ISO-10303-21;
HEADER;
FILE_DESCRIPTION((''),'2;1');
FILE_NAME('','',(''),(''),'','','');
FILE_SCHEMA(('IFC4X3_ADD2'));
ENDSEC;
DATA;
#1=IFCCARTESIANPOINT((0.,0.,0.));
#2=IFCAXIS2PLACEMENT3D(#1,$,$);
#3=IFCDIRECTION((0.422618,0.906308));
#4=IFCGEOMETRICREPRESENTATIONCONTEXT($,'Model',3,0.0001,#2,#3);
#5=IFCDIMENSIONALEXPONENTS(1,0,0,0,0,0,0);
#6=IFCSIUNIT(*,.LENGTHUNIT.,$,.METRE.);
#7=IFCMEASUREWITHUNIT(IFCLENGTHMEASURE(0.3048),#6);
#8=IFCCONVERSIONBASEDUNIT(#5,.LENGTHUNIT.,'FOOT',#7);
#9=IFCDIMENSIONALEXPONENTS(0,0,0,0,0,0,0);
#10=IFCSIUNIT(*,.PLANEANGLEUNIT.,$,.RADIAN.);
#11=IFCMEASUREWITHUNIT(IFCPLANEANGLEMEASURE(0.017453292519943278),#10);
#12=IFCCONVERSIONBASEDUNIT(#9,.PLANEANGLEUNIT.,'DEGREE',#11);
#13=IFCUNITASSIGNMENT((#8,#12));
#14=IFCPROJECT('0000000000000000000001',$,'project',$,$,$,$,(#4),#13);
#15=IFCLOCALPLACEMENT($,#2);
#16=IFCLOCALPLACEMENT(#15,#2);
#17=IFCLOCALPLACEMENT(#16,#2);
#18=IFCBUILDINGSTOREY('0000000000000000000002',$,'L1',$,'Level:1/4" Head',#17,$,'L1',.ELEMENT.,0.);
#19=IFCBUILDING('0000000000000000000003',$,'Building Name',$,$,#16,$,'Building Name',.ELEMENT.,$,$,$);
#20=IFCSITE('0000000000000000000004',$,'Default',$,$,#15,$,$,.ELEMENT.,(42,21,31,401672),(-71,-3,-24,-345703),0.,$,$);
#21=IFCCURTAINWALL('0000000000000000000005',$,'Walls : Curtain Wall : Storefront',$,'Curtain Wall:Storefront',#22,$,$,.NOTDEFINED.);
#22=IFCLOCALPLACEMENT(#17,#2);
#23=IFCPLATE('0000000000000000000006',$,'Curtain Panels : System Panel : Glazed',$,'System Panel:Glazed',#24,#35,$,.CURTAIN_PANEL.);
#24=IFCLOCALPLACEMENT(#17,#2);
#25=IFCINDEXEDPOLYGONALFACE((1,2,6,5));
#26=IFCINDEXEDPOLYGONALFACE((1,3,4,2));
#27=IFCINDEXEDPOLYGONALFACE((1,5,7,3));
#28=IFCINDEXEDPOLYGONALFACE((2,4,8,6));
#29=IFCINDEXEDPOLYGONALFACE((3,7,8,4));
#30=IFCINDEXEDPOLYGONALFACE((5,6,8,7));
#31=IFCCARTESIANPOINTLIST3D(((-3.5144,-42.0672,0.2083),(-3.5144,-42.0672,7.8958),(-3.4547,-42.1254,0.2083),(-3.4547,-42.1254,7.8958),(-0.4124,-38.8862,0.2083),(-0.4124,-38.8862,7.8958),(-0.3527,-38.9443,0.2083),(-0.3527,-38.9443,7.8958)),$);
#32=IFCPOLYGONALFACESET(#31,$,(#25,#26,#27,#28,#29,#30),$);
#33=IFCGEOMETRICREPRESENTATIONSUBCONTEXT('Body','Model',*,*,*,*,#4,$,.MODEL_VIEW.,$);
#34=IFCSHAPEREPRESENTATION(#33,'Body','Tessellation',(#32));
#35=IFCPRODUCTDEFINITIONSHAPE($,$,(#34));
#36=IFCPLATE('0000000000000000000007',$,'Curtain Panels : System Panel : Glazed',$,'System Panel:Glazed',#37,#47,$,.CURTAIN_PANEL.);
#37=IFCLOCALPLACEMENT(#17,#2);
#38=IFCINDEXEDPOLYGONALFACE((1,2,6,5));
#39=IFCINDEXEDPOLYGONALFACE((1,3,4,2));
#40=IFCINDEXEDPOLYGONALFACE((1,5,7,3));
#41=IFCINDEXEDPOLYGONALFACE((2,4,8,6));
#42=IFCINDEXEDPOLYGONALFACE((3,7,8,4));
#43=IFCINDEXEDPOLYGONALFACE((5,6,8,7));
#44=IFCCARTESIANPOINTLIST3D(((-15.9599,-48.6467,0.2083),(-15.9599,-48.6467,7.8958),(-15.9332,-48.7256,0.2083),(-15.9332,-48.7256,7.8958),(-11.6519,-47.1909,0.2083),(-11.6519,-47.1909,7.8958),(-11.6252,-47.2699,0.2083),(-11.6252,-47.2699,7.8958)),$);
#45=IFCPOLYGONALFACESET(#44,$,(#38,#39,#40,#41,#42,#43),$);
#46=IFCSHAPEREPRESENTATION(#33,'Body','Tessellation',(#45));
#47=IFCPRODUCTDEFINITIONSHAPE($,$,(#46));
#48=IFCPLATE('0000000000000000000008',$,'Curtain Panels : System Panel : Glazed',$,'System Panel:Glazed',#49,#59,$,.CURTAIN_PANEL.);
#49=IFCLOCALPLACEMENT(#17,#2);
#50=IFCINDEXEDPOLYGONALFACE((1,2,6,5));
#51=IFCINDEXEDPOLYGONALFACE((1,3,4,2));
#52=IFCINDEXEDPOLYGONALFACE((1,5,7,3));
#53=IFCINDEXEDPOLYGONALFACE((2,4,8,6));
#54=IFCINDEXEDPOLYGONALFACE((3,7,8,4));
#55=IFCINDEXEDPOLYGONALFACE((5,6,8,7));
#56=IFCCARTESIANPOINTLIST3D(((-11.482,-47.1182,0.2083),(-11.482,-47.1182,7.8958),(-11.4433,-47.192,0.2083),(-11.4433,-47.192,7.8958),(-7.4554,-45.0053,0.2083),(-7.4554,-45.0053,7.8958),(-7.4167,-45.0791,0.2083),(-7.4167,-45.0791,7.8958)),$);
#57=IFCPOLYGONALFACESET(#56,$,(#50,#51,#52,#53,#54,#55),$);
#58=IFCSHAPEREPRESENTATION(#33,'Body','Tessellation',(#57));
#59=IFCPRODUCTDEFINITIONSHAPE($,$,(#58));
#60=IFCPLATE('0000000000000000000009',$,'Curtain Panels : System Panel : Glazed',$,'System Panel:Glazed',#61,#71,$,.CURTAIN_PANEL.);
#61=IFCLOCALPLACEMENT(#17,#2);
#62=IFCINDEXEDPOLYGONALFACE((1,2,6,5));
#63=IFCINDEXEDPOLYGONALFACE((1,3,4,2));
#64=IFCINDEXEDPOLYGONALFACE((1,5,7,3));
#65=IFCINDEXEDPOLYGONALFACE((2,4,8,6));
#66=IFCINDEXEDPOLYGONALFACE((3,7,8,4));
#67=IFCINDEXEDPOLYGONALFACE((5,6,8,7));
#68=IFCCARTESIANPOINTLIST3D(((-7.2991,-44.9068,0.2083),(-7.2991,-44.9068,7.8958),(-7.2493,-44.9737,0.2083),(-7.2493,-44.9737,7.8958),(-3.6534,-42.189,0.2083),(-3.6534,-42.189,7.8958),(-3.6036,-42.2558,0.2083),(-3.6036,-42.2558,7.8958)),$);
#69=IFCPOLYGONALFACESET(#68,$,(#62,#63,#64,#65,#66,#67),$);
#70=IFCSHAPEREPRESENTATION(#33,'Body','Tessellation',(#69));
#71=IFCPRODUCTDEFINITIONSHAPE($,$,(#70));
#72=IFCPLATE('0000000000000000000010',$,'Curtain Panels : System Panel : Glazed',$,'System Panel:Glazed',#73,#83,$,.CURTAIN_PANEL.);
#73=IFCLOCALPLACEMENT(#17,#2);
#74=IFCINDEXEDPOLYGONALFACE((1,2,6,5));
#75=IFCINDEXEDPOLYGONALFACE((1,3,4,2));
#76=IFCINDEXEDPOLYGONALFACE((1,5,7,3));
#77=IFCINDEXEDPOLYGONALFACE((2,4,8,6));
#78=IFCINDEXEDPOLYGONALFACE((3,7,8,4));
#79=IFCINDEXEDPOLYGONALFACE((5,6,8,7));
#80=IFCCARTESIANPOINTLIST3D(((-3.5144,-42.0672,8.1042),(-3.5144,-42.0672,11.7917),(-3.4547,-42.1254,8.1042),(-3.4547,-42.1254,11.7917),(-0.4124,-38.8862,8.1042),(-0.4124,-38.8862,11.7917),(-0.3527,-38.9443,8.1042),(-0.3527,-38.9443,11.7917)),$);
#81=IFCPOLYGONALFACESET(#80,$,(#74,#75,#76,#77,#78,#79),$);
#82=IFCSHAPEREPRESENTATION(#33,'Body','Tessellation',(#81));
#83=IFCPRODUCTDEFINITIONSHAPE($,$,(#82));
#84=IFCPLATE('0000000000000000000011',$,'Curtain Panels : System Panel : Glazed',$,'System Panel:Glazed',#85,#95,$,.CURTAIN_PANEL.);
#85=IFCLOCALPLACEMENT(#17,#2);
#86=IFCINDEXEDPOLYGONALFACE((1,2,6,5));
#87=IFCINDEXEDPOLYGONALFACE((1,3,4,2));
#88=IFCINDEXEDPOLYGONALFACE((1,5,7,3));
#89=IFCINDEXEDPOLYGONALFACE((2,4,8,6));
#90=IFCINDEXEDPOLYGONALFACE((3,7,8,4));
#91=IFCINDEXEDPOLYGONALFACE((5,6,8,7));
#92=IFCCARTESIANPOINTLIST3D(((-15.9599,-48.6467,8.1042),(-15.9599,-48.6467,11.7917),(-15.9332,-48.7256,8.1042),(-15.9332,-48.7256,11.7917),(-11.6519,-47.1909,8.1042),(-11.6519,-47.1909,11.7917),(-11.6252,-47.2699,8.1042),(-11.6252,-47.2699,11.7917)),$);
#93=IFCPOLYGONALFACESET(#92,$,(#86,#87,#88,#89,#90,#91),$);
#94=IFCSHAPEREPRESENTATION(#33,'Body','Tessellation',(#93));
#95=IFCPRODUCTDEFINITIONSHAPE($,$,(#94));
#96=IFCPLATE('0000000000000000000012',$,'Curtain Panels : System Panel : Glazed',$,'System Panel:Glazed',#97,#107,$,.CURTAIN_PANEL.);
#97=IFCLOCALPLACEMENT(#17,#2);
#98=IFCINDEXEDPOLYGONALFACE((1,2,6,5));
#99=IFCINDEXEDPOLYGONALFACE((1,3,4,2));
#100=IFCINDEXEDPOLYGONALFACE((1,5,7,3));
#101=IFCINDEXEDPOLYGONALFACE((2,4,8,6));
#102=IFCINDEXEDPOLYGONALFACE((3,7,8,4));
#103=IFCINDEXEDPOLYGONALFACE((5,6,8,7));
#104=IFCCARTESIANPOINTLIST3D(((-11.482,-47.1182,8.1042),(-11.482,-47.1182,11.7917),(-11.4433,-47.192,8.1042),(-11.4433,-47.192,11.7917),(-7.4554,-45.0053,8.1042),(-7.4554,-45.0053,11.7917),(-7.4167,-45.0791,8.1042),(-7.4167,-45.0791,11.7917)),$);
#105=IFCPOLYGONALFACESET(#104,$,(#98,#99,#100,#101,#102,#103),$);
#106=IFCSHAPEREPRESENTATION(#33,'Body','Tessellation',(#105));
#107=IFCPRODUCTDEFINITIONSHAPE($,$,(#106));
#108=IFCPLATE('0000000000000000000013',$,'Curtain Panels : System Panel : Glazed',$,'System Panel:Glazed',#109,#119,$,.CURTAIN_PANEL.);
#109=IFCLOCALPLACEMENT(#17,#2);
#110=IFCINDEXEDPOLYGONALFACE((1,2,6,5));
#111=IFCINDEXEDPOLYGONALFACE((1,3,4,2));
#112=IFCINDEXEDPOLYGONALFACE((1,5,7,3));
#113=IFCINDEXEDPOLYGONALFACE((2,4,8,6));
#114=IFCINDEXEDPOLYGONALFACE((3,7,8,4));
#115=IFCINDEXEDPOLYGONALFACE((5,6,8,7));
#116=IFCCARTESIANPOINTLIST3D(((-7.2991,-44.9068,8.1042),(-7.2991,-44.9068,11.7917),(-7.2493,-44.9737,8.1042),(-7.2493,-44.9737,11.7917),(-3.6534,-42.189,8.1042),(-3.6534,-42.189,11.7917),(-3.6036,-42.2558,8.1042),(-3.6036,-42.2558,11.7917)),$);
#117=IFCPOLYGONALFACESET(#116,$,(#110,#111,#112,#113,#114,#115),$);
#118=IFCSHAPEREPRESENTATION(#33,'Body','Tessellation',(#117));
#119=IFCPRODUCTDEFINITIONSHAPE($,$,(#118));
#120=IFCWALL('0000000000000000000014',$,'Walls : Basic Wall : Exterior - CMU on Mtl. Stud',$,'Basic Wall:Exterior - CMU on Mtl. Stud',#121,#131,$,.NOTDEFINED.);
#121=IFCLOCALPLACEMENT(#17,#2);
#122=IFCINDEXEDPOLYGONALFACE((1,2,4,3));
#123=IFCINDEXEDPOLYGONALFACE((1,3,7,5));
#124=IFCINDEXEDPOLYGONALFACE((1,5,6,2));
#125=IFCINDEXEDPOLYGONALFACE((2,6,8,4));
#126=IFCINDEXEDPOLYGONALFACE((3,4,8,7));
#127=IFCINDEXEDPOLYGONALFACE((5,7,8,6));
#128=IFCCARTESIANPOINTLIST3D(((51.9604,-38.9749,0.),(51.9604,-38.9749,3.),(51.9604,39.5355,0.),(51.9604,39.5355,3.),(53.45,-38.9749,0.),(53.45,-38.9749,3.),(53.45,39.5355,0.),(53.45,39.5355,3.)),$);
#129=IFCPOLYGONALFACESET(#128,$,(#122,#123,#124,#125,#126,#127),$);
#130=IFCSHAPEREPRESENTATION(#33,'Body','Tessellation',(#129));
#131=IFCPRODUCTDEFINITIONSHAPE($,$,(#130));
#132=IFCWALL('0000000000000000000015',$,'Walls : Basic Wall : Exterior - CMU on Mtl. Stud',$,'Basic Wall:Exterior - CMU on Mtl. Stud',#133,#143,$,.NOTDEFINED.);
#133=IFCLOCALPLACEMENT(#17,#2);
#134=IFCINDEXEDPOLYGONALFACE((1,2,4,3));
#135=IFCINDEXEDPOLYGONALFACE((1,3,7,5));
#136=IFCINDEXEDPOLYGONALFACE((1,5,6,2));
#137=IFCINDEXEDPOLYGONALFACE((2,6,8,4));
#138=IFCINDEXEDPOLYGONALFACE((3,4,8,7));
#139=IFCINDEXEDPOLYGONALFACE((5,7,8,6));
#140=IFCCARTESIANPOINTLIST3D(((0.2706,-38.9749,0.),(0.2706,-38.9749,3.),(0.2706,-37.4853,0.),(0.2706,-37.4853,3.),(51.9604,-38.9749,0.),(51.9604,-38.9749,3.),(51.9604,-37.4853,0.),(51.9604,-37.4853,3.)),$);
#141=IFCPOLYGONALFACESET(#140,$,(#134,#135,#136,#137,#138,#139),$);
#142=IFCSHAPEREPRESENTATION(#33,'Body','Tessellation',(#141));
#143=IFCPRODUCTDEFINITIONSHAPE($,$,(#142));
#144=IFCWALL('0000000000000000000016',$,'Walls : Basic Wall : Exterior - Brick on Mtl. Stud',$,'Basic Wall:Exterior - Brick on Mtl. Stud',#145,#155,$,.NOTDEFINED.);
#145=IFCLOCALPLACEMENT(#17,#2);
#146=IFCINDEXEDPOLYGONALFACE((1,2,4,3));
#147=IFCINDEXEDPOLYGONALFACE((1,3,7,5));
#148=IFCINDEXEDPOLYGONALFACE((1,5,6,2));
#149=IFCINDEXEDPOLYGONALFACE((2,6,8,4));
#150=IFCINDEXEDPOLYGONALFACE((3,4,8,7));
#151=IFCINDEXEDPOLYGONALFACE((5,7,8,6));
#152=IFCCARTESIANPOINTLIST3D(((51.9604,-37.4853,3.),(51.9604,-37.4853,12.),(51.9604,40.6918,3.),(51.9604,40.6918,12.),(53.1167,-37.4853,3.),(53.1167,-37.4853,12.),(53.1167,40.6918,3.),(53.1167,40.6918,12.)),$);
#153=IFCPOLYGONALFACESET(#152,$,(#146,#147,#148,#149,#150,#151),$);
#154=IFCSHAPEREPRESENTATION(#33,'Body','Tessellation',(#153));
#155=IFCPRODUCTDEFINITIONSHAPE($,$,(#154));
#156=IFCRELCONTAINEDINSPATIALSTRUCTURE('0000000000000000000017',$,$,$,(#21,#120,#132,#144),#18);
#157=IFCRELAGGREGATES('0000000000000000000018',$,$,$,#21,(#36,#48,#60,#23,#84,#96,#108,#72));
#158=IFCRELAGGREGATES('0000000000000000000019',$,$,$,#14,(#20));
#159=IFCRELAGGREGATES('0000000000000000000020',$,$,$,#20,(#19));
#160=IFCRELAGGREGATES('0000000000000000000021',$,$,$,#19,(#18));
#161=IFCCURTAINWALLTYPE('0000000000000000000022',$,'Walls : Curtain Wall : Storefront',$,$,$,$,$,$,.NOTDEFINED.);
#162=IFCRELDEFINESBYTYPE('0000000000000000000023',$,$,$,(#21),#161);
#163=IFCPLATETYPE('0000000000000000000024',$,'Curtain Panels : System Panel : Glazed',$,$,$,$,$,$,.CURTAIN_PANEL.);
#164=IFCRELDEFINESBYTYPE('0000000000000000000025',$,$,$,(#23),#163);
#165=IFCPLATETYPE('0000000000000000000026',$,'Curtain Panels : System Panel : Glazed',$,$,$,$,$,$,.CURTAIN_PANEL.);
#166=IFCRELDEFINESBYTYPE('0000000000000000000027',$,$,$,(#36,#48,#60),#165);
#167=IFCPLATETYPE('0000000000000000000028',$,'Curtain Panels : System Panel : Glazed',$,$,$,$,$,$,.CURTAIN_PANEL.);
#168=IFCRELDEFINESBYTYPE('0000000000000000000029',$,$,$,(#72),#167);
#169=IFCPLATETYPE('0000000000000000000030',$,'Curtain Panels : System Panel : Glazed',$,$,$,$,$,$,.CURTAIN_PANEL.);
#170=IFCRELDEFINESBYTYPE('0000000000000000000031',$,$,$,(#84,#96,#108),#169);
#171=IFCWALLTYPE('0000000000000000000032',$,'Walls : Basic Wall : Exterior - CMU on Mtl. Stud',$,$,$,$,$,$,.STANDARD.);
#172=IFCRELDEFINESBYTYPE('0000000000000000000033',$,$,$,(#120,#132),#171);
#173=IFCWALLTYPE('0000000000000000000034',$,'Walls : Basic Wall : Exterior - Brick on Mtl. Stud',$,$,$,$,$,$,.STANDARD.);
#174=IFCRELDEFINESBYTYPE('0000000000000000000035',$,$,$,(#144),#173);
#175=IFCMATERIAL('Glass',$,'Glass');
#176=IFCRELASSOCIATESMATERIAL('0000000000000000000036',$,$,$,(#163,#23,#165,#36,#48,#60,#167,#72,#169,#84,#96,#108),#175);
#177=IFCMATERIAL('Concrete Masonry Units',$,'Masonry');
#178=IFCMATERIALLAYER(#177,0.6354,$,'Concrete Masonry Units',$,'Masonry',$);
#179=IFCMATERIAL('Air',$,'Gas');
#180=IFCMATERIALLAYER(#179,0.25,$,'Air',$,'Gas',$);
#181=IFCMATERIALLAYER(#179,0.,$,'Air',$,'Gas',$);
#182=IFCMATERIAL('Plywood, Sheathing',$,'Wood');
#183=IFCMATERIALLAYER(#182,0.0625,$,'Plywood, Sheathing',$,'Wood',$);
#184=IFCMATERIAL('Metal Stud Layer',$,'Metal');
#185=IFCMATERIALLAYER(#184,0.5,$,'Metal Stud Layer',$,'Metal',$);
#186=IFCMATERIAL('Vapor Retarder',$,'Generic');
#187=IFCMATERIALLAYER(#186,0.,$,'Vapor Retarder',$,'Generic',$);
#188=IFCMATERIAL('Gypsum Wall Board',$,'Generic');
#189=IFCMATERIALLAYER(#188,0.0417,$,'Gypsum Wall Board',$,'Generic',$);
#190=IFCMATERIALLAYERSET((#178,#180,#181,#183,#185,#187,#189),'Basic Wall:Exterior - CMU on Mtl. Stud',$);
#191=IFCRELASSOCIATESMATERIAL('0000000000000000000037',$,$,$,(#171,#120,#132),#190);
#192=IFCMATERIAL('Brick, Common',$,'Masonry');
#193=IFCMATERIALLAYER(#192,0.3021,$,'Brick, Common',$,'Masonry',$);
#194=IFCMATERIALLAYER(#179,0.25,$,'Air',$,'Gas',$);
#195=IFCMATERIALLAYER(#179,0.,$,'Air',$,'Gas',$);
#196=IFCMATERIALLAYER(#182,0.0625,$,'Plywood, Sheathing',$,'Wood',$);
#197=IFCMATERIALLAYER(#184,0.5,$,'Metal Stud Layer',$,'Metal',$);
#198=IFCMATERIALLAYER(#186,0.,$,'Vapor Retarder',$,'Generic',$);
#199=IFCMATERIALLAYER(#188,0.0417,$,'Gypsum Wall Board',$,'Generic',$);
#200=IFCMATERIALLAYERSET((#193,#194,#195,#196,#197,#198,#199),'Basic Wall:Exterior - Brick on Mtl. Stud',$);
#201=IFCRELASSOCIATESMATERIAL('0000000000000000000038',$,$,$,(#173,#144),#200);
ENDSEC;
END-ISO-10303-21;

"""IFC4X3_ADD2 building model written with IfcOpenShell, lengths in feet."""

from ifc_helpers import new_model, entity, si_unit, converted_unit, direction, frame, frame_2d, origin, place, context, subcontext, project, spatial, rectangle, extrude, source, transform, mapped, material, layer, layer_set, type_object, type_shapes, element, aggregate, save


model = new_model("IFC4X3_ADD2")

# Units and contexts
model_context = context("Model", 3, precision=0.0001, world=origin(), true_north=direction((0.422618, 0.906308)))
body_context = subcontext(model_context, "Body", "Model", "MODEL_VIEW")
ifc_project = project(units=[converted_unit("LENGTHUNIT", "FOOT", entity("IfcLengthMeasure", 0.3048), si_unit("LENGTHUNIT", "METRE"), dimensions=[1, 0, 0, 0, 0, 0, 0]), converted_unit("PLANEANGLEUNIT", "DEGREE", entity("IfcPlaneAngleMeasure", 0.017453292519943278), si_unit("PLANEANGLEUNIT", "RADIAN"), dimensions=[0, 0, 0, 0, 0, 0, 0])], contexts=[model_context])

# Site, building, storey
site_placement = place(None, origin())
site = spatial("IfcSite", under=ifc_project, at=site_placement, Name="Default", CompositionType="ELEMENT", RefLatitude=(42, 21, 31, 401672), RefLongitude=(-71, -3, -24, -345703), RefElevation=0.0)
building_placement = place(site_placement, origin())
building = spatial("IfcBuilding", under=site, at=building_placement, Name="Building Name", LongName="Building Name", CompositionType="ELEMENT")
storey_placement = place(building_placement, origin())
storey = spatial("IfcBuildingStorey", under=building, at=storey_placement, Name="L1", ObjectType="Level:1/4\" Head", LongName="L1", CompositionType="ELEMENT", Elevation=0.0)

# Curtain wall
curtain_wall_type = type_object("IfcCurtainWallType", Name="Walls : Curtain Wall : Storefront", PredefinedType="NOTDEFINED")
curtain_wall_placement = place(storey_placement, origin())
curtain_wall = element("IfcCurtainWall", 1, at=curtain_wall_placement, inside=storey, type_object=curtain_wall_type, Name="Walls : Curtain Wall : Storefront", ObjectType="Curtain Wall:Storefront", PredefinedType="NOTDEFINED")

# Shared definitions
ifc_material_1 = material(Name="Plywood, Sheathing", Category="Wood")

# Plates
ifc_material_2 = material(Name="Glass", Category="Glass")
plate_type_1 = type_object("IfcPlateType", Name="Curtain Panels : System Panel : Glazed", PredefinedType="CURTAIN_PANEL", material=ifc_material_2)
shared_shape_1 = source(origin(), body_context, "Body", "SweptSolid", [
    extrude(rectangle(XDim=0.0833, YDim=4.4431, at=frame_2d((0.0, 0.0), x_axis=(1.0, 0.0))), frame((2.2216, 0.0417, 0.0), z_axis=(0.0, 0.0, 1.0), x_axis=(0.0, 1.0, 0.0)), (0.0, 0.0, 1.0), 7.6875),
])
type_shapes(plate_type_1, [shared_shape_1])
plate_1_placement = place(curtain_wall_placement, frame((-3.4547, -42.1254, 0.2083), z_axis=(0.0, 0.0, 1.0), x_axis=(0.69815, 0.715952, 0.0)))
plate_1 = element("IfcPlate", 2, at=plate_1_placement, type_object=plate_type_1, material=ifc_material_2, Name="Curtain Panels : System Panel : Glazed", ObjectType="System Panel:Glazed", PredefinedType="CURTAIN_PANEL", context=body_context, shape_type="MappedRepresentation", body=[
    mapped(shared_shape_1, transform((0.0, 0.0, 0.0), scale=1.0)),
])
plate_type_2 = type_object("IfcPlateType", Name="Curtain Panels : System Panel : Glazed", PredefinedType="CURTAIN_PANEL", material=ifc_material_2)
shared_shape_2 = source(origin(), body_context, "Body", "SweptSolid", [
    extrude(rectangle(XDim=0.0833, YDim=4.5473, at=frame_2d((0.0, 0.0), x_axis=(1.0, 0.0))), frame((2.2737, 0.0417, 0.0), z_axis=(0.0, 0.0, 1.0), x_axis=(0.0, 1.0, 0.0)), (0.0, 0.0, 1.0), 7.6875),
])
type_shapes(plate_type_2, [shared_shape_2])
plate_2_placement = place(curtain_wall_placement, frame((-15.9332, -48.7256, 0.2083), z_axis=(0.0, 0.0, 1.0), x_axis=(0.947373, 0.320131, 0.0)))
plate_2 = element("IfcPlate", 3, at=plate_2_placement, type_object=plate_type_2, material=ifc_material_2, Name="Curtain Panels : System Panel : Glazed", ObjectType="System Panel:Glazed", PredefinedType="CURTAIN_PANEL", context=body_context, shape_type="MappedRepresentation", body=[
    mapped(shared_shape_2, transform((0.0, 0.0, 0.0), scale=1.0)),
])
plate_3_placement = place(curtain_wall_placement, frame((-11.4433, -47.192, 0.2083), z_axis=(0.0, 0.0, 1.0), x_axis=(0.885494, 0.464651, 0.0)))
plate_3 = element("IfcPlate", 4, at=plate_3_placement, type_object=plate_type_2, material=ifc_material_2, Name="Curtain Panels : System Panel : Glazed", ObjectType="System Panel:Glazed", PredefinedType="CURTAIN_PANEL", context=body_context, shape_type="MappedRepresentation", body=[
    mapped(shared_shape_2, transform((0.0, 0.0, 0.0), scale=1.0)),
])
plate_4_placement = place(curtain_wall_placement, frame((-7.2493, -44.9737, 0.2083), z_axis=(0.0, 0.0, 1.0), x_axis=(0.801729, 0.597687, 0.0)))
plate_4 = element("IfcPlate", 5, at=plate_4_placement, type_object=plate_type_2, material=ifc_material_2, Name="Curtain Panels : System Panel : Glazed", ObjectType="System Panel:Glazed", PredefinedType="CURTAIN_PANEL", context=body_context, shape_type="MappedRepresentation", body=[
    mapped(shared_shape_2, transform((0.0, 0.0, 0.0), scale=1.0)),
])
plate_type_3 = type_object("IfcPlateType", Name="Curtain Panels : System Panel : Glazed", PredefinedType="CURTAIN_PANEL", material=ifc_material_2)
shared_shape_3 = source(origin(), body_context, "Body", "SweptSolid", [
    extrude(rectangle(XDim=0.0833, YDim=4.4431, at=frame_2d((0.0, 0.0), x_axis=(1.0, 0.0))), frame((2.2216, 0.0417, 0.0), z_axis=(0.0, 0.0, 1.0), x_axis=(0.0, 1.0, 0.0)), (0.0, 0.0, 1.0), 3.6875),
])
type_shapes(plate_type_3, [shared_shape_3])
plate_5_placement = place(curtain_wall_placement, frame((-3.4547, -42.1254, 8.1042), z_axis=(0.0, 0.0, 1.0), x_axis=(0.69815, 0.715952, 0.0)))
plate_5 = element("IfcPlate", 6, at=plate_5_placement, type_object=plate_type_3, material=ifc_material_2, Name="Curtain Panels : System Panel : Glazed", ObjectType="System Panel:Glazed", PredefinedType="CURTAIN_PANEL", context=body_context, shape_type="MappedRepresentation", body=[
    mapped(shared_shape_3, transform((0.0, 0.0, 0.0), scale=1.0)),
])
plate_type_4 = type_object("IfcPlateType", Name="Curtain Panels : System Panel : Glazed", PredefinedType="CURTAIN_PANEL", material=ifc_material_2)
shared_shape_4 = source(origin(), body_context, "Body", "SweptSolid", [
    extrude(rectangle(XDim=0.0833, YDim=4.5473, at=frame_2d((0.0, 0.0), x_axis=(1.0, 0.0))), frame((2.2737, 0.0417, 0.0), z_axis=(0.0, 0.0, 1.0), x_axis=(0.0, 1.0, 0.0)), (0.0, 0.0, 1.0), 3.6875),
])
type_shapes(plate_type_4, [shared_shape_4])
plate_6_placement = place(curtain_wall_placement, frame((-15.9332, -48.7256, 8.1042), z_axis=(0.0, 0.0, 1.0), x_axis=(0.947373, 0.320131, 0.0)))
plate_6 = element("IfcPlate", 7, at=plate_6_placement, type_object=plate_type_4, material=ifc_material_2, Name="Curtain Panels : System Panel : Glazed", ObjectType="System Panel:Glazed", PredefinedType="CURTAIN_PANEL", context=body_context, shape_type="MappedRepresentation", body=[
    mapped(shared_shape_4, transform((0.0, 0.0, 0.0), scale=1.0)),
])
plate_7_placement = place(curtain_wall_placement, frame((-11.4433, -47.192, 8.1042), z_axis=(0.0, 0.0, 1.0), x_axis=(0.885494, 0.464651, 0.0)))
plate_7 = element("IfcPlate", 8, at=plate_7_placement, type_object=plate_type_4, material=ifc_material_2, Name="Curtain Panels : System Panel : Glazed", ObjectType="System Panel:Glazed", PredefinedType="CURTAIN_PANEL", context=body_context, shape_type="MappedRepresentation", body=[
    mapped(shared_shape_4, transform((0.0, 0.0, 0.0), scale=1.0)),
])
plate_8_placement = place(curtain_wall_placement, frame((-7.2493, -44.9737, 8.1042), z_axis=(0.0, 0.0, 1.0), x_axis=(0.801729, 0.597687, 0.0)))
plate_8 = element("IfcPlate", 9, at=plate_8_placement, type_object=plate_type_4, material=ifc_material_2, Name="Curtain Panels : System Panel : Glazed", ObjectType="System Panel:Glazed", PredefinedType="CURTAIN_PANEL", context=body_context, shape_type="MappedRepresentation", body=[
    mapped(shared_shape_4, transform((0.0, 0.0, 0.0), scale=1.0)),
])
aggregate(curtain_wall, [plate_2, plate_3, plate_4, plate_1, plate_6, plate_7, plate_8, plate_5])

# Walls
ifc_material_3 = material(Name="Concrete Masonry Units", Category="Masonry")
ifc_layer_1 = layer(ifc_material_3, 0.6354, Name="Concrete Masonry Units", Category="Masonry")
ifc_material_4 = material(Name="Air", Category="Gas")
ifc_layer_2 = layer(ifc_material_4, 0.25, Name="Air", Category="Gas")
ifc_layer_3 = layer(ifc_material_4, 0.0, Name="Air", Category="Gas")
ifc_layer_4 = layer(ifc_material_1, 0.0625, Name="Plywood, Sheathing", Category="Wood")
ifc_material_5 = material(Name="Metal Stud Layer", Category="Metal")
ifc_layer_5 = layer(ifc_material_5, 0.5, Name="Metal Stud Layer", Category="Metal")
ifc_material_6 = material(Name="Vapor Retarder", Category="Generic")
ifc_layer_6 = layer(ifc_material_6, 0.0, Name="Vapor Retarder", Category="Generic")
ifc_material_7 = material(Name="Gypsum Wall Board", Category="Generic")
ifc_layer_7 = layer(ifc_material_7, 0.0417, Name="Gypsum Wall Board", Category="Generic")
ifc_layer_set_1 = layer_set([ifc_layer_1, ifc_layer_2, ifc_layer_3, ifc_layer_4, ifc_layer_5, ifc_layer_6, ifc_layer_7], Name="Basic Wall:Exterior - CMU on Mtl. Stud")
wall_type_1 = type_object("IfcWallType", Name="Walls : Basic Wall : Exterior - CMU on Mtl. Stud", PredefinedType="STANDARD", material=ifc_layer_set_1)
wall_1_placement = place(storey_placement, frame((52.7052, 39.5355, 0.0), z_axis=(0.0, 0.0, 1.0), x_axis=(0.0, -1.0, 0.0)))
element("IfcWall", 10, at=wall_1_placement, inside=storey, type_object=wall_type_1, material=ifc_layer_set_1, Name="Walls : Basic Wall : Exterior - CMU on Mtl. Stud", ObjectType="Basic Wall:Exterior - CMU on Mtl. Stud", PredefinedType="NOTDEFINED", context=body_context, shape_type="SweptSolid", body=[
    extrude(rectangle(XDim=78.5104, YDim=1.4896, at=frame_2d((39.2552, 0.0), x_axis=(-1.0, 0.0))), origin(), (0.0, 0.0, 1.0), 3.0),
])
wall_2_placement = place(storey_placement, frame((51.9604, -38.2301, 0.0), z_axis=(0.0, 0.0, 1.0), x_axis=(-1.0, 0.0, 0.0)))
element("IfcWall", 11, at=wall_2_placement, inside=storey, type_object=wall_type_1, material=ifc_layer_set_1, Name="Walls : Basic Wall : Exterior - CMU on Mtl. Stud", ObjectType="Basic Wall:Exterior - CMU on Mtl. Stud", PredefinedType="NOTDEFINED", context=body_context, shape_type="SweptSolid", body=[
    extrude(rectangle(XDim=51.6898, YDim=1.4896, at=frame_2d((25.8449, 0.0), x_axis=(-1.0, 0.0))), origin(), (0.0, 0.0, 1.0), 3.0),
])
ifc_material_8 = material(Name="Brick, Common", Category="Masonry")
ifc_layer_8 = layer(ifc_material_8, 0.3021, Name="Brick, Common", Category="Masonry")
ifc_layer_9 = layer(ifc_material_4, 0.25, Name="Air", Category="Gas")
ifc_layer_10 = layer(ifc_material_4, 0.0, Name="Air", Category="Gas")
ifc_layer_11 = layer(ifc_material_1, 0.0625, Name="Plywood, Sheathing", Category="Wood")
ifc_layer_12 = layer(ifc_material_5, 0.5, Name="Metal Stud Layer", Category="Metal")
ifc_layer_13 = layer(ifc_material_6, 0.0, Name="Vapor Retarder", Category="Generic")
ifc_layer_14 = layer(ifc_material_7, 0.0417, Name="Gypsum Wall Board", Category="Generic")
ifc_layer_set_2 = layer_set([ifc_layer_8, ifc_layer_9, ifc_layer_10, ifc_layer_11, ifc_layer_12, ifc_layer_13, ifc_layer_14], Name="Basic Wall:Exterior - Brick on Mtl. Stud")
wall_type_2 = type_object("IfcWallType", Name="Walls : Basic Wall : Exterior - Brick on Mtl. Stud", PredefinedType="STANDARD", material=ifc_layer_set_2)
wall_3_placement = place(storey_placement, frame((52.5386, 40.6918, 3.0), z_axis=(0.0, 0.0, 1.0), x_axis=(0.0, -1.0, 0.0)))
element("IfcWall", 12, at=wall_3_placement, inside=storey, type_object=wall_type_2, material=ifc_layer_set_2, Name="Walls : Basic Wall : Exterior - Brick on Mtl. Stud", ObjectType="Basic Wall:Exterior - Brick on Mtl. Stud", PredefinedType="NOTDEFINED", context=body_context, shape_type="SweptSolid", body=[
    extrude(rectangle(XDim=78.1771, YDim=1.1562, at=frame_2d((39.0885, 0.0), x_axis=(-1.0, 0.0))), origin(), (0.0, 0.0, 1.0), 9.0),
])

save(model, "model.ifc")
